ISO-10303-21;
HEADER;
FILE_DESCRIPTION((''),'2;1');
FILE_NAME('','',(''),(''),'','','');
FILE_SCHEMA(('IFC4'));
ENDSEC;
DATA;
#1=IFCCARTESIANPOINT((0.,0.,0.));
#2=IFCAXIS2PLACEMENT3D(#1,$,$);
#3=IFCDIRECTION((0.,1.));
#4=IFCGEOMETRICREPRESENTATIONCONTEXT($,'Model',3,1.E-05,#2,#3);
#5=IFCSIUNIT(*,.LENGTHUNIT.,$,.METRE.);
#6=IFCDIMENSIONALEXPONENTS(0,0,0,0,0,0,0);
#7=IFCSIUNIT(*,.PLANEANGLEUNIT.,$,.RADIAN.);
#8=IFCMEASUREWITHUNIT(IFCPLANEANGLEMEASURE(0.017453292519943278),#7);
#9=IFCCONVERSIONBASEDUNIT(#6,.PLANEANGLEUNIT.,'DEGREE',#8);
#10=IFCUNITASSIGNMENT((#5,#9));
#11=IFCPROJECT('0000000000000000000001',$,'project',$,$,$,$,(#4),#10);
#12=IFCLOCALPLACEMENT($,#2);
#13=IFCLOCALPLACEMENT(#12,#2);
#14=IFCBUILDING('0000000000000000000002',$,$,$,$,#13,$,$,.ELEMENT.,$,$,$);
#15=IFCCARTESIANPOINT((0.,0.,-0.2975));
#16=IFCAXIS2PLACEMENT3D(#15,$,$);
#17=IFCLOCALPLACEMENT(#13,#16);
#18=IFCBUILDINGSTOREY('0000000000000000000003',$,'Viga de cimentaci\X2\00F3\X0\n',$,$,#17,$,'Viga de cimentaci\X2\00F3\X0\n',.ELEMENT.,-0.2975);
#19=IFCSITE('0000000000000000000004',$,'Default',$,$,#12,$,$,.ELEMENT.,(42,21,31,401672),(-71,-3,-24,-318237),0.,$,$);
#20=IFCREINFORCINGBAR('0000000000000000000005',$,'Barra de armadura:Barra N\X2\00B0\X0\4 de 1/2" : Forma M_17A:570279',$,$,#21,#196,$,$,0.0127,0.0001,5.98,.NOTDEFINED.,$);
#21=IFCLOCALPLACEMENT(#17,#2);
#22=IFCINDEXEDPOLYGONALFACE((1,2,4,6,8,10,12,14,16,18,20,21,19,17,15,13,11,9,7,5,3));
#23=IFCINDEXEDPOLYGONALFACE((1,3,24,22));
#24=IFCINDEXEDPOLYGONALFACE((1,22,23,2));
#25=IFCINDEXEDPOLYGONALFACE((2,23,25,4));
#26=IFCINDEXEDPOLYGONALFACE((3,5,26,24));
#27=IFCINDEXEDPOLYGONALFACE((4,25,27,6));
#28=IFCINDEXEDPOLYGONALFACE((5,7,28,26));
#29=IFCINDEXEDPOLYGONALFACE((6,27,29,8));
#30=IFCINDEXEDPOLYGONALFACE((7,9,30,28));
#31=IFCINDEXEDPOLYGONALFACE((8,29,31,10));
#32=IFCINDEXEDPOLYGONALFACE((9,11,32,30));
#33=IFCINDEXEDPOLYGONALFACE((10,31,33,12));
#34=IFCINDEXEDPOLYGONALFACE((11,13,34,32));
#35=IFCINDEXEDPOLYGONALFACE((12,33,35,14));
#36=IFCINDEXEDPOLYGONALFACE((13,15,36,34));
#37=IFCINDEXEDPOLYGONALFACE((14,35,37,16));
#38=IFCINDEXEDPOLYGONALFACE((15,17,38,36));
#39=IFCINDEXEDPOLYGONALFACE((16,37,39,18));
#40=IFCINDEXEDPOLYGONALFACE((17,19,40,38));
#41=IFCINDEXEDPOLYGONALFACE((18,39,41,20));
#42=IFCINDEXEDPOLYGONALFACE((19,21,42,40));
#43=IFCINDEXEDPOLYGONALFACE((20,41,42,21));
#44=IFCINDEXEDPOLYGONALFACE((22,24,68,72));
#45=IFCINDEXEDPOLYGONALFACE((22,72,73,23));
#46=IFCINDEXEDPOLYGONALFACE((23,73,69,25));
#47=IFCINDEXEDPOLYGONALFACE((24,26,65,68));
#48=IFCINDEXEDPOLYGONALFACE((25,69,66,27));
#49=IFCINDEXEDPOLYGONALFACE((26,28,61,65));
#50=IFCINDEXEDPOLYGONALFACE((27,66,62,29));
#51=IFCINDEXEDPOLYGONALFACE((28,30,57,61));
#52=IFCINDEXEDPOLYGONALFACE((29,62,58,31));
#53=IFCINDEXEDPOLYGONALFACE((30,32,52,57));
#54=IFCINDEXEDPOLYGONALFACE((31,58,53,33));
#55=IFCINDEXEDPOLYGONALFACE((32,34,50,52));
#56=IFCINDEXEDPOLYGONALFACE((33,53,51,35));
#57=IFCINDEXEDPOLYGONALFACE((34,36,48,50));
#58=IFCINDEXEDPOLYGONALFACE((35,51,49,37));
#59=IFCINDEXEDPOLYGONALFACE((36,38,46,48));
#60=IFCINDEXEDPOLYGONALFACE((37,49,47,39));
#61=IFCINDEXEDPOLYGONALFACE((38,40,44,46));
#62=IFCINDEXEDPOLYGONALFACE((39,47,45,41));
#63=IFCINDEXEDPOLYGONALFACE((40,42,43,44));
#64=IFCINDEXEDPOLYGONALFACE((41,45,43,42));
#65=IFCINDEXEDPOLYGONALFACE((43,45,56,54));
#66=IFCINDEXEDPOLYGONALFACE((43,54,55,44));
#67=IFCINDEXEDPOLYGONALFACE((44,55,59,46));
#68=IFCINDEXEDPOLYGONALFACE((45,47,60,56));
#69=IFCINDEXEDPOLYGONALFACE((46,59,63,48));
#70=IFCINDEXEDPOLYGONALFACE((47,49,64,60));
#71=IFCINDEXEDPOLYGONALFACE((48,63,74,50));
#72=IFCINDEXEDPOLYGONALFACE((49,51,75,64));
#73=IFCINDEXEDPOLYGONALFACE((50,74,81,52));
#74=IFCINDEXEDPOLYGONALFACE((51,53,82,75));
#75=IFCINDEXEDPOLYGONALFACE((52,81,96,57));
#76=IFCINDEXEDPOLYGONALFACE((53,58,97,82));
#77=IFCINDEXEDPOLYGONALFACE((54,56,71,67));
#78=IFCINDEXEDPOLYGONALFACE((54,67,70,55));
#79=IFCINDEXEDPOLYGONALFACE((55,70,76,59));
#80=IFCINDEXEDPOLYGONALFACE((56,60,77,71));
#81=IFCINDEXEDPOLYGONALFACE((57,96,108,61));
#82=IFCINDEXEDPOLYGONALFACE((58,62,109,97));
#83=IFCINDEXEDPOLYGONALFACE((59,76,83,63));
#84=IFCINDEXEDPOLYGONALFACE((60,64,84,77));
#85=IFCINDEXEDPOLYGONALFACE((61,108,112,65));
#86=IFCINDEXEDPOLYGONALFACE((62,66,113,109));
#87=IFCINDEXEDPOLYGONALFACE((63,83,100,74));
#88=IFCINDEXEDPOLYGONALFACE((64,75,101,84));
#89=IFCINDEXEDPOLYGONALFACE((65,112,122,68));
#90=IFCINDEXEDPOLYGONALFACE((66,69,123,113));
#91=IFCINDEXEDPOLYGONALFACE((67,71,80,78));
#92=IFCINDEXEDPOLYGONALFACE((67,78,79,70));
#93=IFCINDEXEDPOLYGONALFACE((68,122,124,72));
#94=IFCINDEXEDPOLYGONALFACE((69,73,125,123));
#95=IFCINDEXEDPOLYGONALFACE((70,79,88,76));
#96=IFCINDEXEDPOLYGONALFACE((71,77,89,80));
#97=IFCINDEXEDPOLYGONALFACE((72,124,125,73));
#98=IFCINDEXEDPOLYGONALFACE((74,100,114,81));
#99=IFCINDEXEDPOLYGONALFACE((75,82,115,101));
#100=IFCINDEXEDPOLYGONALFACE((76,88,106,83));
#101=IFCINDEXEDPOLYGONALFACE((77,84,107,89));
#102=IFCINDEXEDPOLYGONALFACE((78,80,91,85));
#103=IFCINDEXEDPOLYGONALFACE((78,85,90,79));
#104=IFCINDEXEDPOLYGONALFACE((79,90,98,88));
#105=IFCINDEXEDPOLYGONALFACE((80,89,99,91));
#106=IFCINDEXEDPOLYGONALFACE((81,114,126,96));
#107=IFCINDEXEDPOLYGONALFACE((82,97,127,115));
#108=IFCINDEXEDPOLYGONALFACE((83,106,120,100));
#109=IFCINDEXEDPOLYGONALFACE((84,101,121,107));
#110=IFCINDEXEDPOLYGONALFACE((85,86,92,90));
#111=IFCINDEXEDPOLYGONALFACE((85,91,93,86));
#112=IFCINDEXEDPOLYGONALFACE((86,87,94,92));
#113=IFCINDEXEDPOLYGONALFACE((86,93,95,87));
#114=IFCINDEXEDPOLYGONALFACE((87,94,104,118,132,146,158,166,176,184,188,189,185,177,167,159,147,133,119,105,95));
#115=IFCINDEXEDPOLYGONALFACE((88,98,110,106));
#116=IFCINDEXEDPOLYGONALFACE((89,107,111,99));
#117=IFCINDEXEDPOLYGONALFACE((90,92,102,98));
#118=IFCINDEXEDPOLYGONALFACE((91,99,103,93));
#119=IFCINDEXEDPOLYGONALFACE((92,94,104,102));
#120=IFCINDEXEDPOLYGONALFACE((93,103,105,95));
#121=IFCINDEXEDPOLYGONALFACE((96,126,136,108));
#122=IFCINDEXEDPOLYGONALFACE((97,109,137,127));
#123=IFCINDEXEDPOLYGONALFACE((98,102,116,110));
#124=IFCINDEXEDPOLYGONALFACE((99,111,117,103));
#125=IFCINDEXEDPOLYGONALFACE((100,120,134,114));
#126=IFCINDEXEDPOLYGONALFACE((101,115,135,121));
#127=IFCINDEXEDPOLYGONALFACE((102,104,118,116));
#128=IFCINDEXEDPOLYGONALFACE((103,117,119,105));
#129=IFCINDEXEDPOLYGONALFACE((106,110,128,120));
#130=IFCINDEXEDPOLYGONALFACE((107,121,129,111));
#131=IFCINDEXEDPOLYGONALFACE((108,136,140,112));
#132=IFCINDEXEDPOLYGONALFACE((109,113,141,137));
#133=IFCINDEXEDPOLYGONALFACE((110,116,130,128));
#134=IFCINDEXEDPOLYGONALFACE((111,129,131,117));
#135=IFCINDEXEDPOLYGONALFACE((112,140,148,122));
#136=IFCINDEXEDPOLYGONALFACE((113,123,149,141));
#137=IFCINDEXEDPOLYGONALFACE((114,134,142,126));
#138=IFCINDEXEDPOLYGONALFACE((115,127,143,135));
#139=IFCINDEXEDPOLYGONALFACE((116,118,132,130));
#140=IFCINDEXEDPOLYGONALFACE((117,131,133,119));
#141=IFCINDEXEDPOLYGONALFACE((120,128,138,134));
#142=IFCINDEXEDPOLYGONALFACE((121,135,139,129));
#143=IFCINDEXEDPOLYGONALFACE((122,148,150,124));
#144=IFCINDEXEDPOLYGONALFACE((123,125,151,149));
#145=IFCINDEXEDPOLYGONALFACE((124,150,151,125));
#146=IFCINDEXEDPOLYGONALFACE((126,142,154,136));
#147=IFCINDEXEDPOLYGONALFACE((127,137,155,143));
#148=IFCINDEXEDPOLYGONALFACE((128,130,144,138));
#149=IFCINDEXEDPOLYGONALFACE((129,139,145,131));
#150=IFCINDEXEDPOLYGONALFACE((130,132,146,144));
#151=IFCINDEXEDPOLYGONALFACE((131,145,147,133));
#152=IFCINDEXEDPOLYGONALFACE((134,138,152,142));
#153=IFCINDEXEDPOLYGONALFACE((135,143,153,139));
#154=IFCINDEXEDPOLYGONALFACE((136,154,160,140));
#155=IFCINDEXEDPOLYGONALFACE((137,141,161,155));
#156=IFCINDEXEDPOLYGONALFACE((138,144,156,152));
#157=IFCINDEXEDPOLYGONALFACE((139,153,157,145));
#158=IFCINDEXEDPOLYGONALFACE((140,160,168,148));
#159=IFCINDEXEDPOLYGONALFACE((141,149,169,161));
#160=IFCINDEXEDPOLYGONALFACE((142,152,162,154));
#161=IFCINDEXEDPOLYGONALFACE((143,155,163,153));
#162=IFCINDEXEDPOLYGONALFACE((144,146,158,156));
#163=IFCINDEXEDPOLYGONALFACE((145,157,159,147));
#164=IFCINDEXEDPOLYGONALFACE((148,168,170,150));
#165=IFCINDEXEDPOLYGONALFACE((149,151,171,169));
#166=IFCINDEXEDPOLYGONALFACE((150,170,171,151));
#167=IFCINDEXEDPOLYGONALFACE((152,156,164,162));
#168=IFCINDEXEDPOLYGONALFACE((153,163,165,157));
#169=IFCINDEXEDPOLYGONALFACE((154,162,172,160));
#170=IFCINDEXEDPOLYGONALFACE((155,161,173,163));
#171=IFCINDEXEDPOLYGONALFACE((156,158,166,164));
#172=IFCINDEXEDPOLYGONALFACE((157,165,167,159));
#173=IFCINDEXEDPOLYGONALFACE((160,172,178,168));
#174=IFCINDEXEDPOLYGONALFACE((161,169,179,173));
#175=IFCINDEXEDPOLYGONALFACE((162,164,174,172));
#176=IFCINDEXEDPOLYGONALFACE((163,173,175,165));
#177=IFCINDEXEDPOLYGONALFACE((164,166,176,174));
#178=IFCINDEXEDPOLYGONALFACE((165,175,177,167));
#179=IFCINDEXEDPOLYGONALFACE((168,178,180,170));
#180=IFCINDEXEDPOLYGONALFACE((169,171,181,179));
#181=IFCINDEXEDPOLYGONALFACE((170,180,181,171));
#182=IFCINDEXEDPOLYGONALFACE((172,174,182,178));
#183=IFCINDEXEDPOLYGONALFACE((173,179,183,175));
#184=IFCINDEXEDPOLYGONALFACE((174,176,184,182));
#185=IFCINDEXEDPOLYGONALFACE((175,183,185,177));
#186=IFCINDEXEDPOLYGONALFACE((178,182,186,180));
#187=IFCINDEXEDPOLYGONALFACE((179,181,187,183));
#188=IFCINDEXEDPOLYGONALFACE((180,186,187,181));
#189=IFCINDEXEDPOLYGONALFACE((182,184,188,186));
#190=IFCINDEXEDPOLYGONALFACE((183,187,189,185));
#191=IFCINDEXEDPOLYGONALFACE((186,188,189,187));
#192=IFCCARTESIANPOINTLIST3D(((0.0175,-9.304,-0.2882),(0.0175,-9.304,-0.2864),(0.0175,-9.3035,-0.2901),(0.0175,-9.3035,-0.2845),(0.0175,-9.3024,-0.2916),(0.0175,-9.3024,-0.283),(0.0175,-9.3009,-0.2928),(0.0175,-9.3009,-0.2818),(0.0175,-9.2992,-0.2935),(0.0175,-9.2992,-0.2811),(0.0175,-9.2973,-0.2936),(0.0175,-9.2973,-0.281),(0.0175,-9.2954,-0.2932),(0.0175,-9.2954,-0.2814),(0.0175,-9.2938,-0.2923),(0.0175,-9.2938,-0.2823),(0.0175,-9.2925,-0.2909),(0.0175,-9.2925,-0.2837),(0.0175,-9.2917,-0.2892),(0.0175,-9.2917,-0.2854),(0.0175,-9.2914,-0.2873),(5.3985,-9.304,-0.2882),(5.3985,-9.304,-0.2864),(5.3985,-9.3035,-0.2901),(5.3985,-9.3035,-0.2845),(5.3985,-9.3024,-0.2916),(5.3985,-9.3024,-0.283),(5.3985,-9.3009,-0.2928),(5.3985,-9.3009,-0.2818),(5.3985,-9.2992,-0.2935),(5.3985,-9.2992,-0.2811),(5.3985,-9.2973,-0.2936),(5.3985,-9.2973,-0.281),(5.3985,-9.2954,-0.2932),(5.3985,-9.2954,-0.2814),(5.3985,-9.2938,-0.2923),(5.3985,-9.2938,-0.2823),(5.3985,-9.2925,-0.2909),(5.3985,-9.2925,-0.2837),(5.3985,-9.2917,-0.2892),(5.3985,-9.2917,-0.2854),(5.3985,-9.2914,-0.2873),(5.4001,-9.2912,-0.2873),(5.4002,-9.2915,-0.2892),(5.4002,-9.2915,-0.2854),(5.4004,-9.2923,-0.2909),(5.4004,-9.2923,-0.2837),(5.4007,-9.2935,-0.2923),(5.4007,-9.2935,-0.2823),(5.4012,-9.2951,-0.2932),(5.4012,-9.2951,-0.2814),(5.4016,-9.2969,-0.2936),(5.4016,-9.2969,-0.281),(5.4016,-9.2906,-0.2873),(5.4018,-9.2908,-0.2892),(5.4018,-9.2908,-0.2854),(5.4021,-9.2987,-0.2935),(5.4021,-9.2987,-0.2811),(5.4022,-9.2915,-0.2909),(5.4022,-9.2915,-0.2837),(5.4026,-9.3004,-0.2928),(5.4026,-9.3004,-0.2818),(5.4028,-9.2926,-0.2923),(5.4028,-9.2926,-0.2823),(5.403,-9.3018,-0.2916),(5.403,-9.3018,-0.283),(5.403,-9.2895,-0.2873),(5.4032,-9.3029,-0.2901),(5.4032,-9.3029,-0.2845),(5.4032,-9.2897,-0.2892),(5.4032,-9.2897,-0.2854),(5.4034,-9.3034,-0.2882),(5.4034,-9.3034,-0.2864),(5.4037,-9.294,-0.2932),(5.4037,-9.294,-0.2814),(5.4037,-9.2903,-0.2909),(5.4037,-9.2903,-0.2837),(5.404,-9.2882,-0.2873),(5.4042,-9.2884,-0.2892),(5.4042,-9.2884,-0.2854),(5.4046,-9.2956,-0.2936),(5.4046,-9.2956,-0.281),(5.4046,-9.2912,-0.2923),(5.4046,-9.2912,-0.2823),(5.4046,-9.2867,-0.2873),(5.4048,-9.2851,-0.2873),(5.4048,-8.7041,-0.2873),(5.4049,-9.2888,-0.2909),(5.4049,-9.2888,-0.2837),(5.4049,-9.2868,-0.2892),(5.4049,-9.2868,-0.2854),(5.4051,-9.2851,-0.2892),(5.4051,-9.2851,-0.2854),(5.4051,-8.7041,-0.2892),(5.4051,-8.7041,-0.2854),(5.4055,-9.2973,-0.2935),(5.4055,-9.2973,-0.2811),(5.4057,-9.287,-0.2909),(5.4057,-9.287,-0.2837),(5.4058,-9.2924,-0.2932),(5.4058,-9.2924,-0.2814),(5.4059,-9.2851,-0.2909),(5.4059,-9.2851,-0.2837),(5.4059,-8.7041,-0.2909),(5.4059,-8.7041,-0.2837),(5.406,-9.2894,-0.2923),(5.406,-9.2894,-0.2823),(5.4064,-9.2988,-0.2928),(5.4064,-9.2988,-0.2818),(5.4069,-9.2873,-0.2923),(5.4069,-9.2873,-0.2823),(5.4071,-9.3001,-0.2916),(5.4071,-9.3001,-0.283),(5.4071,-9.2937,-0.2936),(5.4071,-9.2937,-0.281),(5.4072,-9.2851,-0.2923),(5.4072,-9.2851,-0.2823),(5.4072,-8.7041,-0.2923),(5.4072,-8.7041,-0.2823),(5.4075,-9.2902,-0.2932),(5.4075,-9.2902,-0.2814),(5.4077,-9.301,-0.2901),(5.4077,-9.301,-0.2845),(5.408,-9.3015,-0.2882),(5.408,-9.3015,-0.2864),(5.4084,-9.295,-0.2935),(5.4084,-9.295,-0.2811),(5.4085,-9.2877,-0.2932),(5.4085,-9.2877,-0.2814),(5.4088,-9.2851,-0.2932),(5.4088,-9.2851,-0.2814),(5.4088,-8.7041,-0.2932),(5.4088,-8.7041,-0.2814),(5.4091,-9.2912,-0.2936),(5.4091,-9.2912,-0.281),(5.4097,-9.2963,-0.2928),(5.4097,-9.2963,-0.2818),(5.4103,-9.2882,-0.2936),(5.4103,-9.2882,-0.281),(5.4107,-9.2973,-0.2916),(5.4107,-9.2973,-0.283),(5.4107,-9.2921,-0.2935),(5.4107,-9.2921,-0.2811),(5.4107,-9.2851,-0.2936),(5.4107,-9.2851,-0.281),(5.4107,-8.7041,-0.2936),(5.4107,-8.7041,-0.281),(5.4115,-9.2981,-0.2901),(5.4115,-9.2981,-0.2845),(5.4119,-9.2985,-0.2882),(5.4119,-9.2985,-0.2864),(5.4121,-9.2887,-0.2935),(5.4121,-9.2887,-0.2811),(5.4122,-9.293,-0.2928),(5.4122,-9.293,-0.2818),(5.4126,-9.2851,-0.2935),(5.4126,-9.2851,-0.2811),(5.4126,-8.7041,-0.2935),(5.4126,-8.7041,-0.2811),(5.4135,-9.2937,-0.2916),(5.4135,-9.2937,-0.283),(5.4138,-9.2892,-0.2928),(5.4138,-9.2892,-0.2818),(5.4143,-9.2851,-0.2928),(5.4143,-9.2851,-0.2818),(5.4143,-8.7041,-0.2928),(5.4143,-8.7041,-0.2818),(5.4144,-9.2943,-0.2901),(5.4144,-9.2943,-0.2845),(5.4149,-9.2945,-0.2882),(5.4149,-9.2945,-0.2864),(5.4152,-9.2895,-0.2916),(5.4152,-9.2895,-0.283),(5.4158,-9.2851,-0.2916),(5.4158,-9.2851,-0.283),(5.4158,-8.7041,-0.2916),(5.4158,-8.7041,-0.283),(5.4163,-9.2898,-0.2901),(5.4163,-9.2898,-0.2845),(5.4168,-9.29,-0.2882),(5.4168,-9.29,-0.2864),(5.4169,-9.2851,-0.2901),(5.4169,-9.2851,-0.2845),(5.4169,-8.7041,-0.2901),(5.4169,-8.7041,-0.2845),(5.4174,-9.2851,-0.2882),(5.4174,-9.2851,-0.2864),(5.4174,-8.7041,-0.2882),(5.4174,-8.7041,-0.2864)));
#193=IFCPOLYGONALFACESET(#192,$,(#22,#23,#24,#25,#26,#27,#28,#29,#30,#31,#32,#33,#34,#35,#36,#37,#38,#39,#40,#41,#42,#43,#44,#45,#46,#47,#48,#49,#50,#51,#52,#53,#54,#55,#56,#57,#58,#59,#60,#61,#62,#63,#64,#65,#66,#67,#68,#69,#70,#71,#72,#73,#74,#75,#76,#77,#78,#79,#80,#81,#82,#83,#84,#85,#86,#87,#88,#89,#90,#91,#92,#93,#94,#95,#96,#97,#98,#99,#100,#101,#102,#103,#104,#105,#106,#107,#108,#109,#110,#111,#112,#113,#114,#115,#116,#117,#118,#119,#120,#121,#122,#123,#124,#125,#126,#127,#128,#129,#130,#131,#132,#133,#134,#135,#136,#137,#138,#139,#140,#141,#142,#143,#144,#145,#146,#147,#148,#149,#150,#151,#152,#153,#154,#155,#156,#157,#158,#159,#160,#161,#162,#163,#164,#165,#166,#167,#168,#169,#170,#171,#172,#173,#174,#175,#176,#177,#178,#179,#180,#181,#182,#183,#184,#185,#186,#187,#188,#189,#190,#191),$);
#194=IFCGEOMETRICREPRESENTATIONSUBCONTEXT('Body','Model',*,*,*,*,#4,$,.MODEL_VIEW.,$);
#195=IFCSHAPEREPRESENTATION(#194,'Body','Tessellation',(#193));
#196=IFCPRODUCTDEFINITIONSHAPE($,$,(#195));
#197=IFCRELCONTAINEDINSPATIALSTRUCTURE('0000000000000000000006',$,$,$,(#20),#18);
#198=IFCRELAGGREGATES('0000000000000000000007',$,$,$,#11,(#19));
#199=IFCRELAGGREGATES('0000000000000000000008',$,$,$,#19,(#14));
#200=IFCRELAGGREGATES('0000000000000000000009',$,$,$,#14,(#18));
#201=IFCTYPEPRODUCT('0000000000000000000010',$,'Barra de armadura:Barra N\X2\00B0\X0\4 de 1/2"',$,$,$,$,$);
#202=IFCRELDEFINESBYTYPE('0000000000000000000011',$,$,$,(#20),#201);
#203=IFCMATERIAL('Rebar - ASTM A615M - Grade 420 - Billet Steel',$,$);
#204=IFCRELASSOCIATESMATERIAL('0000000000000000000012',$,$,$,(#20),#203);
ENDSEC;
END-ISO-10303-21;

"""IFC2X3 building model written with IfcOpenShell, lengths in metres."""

from ifc_helpers import new_model, entity, si_unit, converted_unit, direction, frame, origin, place, context, subcontext, project, spatial, material, type_object, element, save


model = new_model("IFC2X3")

# Units and contexts
model_context = context("Model", 3, precision=1e-05, world=origin(), true_north=direction((0.0, 1.0)))
body_context = subcontext(model_context, "Body", "Model", "MODEL_VIEW")
ifc_project = project(units=[si_unit("LENGTHUNIT", "METRE"), converted_unit("PLANEANGLEUNIT", "DEGREE", entity("IfcPlaneAngleMeasure", 0.017453292519943278), si_unit("PLANEANGLEUNIT", "RADIAN"), dimensions=[0, 0, 0, 0, 0, 0, 0])], contexts=[model_context])

# Site, building, storey
site_placement = place(None, origin())
site = spatial("IfcSite", under=ifc_project, at=site_placement, Name="Default", CompositionType="ELEMENT", RefLatitude=(42, 21, 31, 401672), RefLongitude=(-71, -3, -24, -318237), RefElevation=0.0)
building_placement = place(site_placement, origin())
building = spatial("IfcBuilding", under=site, at=building_placement, CompositionType="ELEMENT")
storey_placement = place(building_placement, frame((0.0, 0.0, -0.2975)))
storey = spatial("IfcBuildingStorey", under=building, at=storey_placement, Name="Viga de cimentación", LongName="Viga de cimentación", CompositionType="ELEMENT", Elevation=-0.2975)

# Reinforcing bar
ifc_material = material(Name="Rebar - ASTM A615M - Grade 420 - Billet Steel")
type_product_1 = type_object("IfcTypeProduct", Name="Barra de armadura:Barra N°4 de 1/2\"")
reinforcing_bar_1_placement = place(storey_placement, origin())
element("IfcReinforcingBar", 1, at=reinforcing_bar_1_placement, inside=storey, type_object=type_product_1, material=ifc_material, Name="Barra de armadura:Barra N°4 de 1/2\" : Forma M_17A:570279", BarLength=5.98, BarRole="NOTDEFINED", CrossSectionArea=0.0001, NominalDiameter=0.0127, context=body_context, shape_type="AdvancedSweptSolid", body=[
    entity("IfcSweptDiskSolid", entity("IfcCompositeCurve", [entity("IfcCompositeCurveSegment", "CONTINUOUS", True, entity("IfcPolyline", [entity("IfcCartesianPoint", [5.4112, -8.7041, -0.2873]), entity("IfcCartesianPoint", [5.4112, -9.2851, -0.2873])])), entity("IfcCompositeCurveSegment", "CONTINUOUS", True, entity("IfcTrimmedCurve", entity("IfcCircle", entity("IfcAxis2Placement3D", entity("IfcCartesianPoint", [5.3985, -9.2851, -0.2873]), entity("IfcDirection", [0.0, 0.0, -1.0]), entity("IfcDirection", [0.0, -1.0, 0.0])), 0.0127), [entity("IfcParameterValue", 270.0)], [entity("IfcParameterValue", 360.0)], True, "PARAMETER")), entity("IfcCompositeCurveSegment", "CONTINUOUS", True, entity("IfcPolyline", [entity("IfcCartesianPoint", [5.3985, -9.2978, -0.2873]), entity("IfcCartesianPoint", [0.0175, -9.2978, -0.2873])]))], False), 0.0063, None, 0.0, 92.0),
])

save(model, "model.ifc")
